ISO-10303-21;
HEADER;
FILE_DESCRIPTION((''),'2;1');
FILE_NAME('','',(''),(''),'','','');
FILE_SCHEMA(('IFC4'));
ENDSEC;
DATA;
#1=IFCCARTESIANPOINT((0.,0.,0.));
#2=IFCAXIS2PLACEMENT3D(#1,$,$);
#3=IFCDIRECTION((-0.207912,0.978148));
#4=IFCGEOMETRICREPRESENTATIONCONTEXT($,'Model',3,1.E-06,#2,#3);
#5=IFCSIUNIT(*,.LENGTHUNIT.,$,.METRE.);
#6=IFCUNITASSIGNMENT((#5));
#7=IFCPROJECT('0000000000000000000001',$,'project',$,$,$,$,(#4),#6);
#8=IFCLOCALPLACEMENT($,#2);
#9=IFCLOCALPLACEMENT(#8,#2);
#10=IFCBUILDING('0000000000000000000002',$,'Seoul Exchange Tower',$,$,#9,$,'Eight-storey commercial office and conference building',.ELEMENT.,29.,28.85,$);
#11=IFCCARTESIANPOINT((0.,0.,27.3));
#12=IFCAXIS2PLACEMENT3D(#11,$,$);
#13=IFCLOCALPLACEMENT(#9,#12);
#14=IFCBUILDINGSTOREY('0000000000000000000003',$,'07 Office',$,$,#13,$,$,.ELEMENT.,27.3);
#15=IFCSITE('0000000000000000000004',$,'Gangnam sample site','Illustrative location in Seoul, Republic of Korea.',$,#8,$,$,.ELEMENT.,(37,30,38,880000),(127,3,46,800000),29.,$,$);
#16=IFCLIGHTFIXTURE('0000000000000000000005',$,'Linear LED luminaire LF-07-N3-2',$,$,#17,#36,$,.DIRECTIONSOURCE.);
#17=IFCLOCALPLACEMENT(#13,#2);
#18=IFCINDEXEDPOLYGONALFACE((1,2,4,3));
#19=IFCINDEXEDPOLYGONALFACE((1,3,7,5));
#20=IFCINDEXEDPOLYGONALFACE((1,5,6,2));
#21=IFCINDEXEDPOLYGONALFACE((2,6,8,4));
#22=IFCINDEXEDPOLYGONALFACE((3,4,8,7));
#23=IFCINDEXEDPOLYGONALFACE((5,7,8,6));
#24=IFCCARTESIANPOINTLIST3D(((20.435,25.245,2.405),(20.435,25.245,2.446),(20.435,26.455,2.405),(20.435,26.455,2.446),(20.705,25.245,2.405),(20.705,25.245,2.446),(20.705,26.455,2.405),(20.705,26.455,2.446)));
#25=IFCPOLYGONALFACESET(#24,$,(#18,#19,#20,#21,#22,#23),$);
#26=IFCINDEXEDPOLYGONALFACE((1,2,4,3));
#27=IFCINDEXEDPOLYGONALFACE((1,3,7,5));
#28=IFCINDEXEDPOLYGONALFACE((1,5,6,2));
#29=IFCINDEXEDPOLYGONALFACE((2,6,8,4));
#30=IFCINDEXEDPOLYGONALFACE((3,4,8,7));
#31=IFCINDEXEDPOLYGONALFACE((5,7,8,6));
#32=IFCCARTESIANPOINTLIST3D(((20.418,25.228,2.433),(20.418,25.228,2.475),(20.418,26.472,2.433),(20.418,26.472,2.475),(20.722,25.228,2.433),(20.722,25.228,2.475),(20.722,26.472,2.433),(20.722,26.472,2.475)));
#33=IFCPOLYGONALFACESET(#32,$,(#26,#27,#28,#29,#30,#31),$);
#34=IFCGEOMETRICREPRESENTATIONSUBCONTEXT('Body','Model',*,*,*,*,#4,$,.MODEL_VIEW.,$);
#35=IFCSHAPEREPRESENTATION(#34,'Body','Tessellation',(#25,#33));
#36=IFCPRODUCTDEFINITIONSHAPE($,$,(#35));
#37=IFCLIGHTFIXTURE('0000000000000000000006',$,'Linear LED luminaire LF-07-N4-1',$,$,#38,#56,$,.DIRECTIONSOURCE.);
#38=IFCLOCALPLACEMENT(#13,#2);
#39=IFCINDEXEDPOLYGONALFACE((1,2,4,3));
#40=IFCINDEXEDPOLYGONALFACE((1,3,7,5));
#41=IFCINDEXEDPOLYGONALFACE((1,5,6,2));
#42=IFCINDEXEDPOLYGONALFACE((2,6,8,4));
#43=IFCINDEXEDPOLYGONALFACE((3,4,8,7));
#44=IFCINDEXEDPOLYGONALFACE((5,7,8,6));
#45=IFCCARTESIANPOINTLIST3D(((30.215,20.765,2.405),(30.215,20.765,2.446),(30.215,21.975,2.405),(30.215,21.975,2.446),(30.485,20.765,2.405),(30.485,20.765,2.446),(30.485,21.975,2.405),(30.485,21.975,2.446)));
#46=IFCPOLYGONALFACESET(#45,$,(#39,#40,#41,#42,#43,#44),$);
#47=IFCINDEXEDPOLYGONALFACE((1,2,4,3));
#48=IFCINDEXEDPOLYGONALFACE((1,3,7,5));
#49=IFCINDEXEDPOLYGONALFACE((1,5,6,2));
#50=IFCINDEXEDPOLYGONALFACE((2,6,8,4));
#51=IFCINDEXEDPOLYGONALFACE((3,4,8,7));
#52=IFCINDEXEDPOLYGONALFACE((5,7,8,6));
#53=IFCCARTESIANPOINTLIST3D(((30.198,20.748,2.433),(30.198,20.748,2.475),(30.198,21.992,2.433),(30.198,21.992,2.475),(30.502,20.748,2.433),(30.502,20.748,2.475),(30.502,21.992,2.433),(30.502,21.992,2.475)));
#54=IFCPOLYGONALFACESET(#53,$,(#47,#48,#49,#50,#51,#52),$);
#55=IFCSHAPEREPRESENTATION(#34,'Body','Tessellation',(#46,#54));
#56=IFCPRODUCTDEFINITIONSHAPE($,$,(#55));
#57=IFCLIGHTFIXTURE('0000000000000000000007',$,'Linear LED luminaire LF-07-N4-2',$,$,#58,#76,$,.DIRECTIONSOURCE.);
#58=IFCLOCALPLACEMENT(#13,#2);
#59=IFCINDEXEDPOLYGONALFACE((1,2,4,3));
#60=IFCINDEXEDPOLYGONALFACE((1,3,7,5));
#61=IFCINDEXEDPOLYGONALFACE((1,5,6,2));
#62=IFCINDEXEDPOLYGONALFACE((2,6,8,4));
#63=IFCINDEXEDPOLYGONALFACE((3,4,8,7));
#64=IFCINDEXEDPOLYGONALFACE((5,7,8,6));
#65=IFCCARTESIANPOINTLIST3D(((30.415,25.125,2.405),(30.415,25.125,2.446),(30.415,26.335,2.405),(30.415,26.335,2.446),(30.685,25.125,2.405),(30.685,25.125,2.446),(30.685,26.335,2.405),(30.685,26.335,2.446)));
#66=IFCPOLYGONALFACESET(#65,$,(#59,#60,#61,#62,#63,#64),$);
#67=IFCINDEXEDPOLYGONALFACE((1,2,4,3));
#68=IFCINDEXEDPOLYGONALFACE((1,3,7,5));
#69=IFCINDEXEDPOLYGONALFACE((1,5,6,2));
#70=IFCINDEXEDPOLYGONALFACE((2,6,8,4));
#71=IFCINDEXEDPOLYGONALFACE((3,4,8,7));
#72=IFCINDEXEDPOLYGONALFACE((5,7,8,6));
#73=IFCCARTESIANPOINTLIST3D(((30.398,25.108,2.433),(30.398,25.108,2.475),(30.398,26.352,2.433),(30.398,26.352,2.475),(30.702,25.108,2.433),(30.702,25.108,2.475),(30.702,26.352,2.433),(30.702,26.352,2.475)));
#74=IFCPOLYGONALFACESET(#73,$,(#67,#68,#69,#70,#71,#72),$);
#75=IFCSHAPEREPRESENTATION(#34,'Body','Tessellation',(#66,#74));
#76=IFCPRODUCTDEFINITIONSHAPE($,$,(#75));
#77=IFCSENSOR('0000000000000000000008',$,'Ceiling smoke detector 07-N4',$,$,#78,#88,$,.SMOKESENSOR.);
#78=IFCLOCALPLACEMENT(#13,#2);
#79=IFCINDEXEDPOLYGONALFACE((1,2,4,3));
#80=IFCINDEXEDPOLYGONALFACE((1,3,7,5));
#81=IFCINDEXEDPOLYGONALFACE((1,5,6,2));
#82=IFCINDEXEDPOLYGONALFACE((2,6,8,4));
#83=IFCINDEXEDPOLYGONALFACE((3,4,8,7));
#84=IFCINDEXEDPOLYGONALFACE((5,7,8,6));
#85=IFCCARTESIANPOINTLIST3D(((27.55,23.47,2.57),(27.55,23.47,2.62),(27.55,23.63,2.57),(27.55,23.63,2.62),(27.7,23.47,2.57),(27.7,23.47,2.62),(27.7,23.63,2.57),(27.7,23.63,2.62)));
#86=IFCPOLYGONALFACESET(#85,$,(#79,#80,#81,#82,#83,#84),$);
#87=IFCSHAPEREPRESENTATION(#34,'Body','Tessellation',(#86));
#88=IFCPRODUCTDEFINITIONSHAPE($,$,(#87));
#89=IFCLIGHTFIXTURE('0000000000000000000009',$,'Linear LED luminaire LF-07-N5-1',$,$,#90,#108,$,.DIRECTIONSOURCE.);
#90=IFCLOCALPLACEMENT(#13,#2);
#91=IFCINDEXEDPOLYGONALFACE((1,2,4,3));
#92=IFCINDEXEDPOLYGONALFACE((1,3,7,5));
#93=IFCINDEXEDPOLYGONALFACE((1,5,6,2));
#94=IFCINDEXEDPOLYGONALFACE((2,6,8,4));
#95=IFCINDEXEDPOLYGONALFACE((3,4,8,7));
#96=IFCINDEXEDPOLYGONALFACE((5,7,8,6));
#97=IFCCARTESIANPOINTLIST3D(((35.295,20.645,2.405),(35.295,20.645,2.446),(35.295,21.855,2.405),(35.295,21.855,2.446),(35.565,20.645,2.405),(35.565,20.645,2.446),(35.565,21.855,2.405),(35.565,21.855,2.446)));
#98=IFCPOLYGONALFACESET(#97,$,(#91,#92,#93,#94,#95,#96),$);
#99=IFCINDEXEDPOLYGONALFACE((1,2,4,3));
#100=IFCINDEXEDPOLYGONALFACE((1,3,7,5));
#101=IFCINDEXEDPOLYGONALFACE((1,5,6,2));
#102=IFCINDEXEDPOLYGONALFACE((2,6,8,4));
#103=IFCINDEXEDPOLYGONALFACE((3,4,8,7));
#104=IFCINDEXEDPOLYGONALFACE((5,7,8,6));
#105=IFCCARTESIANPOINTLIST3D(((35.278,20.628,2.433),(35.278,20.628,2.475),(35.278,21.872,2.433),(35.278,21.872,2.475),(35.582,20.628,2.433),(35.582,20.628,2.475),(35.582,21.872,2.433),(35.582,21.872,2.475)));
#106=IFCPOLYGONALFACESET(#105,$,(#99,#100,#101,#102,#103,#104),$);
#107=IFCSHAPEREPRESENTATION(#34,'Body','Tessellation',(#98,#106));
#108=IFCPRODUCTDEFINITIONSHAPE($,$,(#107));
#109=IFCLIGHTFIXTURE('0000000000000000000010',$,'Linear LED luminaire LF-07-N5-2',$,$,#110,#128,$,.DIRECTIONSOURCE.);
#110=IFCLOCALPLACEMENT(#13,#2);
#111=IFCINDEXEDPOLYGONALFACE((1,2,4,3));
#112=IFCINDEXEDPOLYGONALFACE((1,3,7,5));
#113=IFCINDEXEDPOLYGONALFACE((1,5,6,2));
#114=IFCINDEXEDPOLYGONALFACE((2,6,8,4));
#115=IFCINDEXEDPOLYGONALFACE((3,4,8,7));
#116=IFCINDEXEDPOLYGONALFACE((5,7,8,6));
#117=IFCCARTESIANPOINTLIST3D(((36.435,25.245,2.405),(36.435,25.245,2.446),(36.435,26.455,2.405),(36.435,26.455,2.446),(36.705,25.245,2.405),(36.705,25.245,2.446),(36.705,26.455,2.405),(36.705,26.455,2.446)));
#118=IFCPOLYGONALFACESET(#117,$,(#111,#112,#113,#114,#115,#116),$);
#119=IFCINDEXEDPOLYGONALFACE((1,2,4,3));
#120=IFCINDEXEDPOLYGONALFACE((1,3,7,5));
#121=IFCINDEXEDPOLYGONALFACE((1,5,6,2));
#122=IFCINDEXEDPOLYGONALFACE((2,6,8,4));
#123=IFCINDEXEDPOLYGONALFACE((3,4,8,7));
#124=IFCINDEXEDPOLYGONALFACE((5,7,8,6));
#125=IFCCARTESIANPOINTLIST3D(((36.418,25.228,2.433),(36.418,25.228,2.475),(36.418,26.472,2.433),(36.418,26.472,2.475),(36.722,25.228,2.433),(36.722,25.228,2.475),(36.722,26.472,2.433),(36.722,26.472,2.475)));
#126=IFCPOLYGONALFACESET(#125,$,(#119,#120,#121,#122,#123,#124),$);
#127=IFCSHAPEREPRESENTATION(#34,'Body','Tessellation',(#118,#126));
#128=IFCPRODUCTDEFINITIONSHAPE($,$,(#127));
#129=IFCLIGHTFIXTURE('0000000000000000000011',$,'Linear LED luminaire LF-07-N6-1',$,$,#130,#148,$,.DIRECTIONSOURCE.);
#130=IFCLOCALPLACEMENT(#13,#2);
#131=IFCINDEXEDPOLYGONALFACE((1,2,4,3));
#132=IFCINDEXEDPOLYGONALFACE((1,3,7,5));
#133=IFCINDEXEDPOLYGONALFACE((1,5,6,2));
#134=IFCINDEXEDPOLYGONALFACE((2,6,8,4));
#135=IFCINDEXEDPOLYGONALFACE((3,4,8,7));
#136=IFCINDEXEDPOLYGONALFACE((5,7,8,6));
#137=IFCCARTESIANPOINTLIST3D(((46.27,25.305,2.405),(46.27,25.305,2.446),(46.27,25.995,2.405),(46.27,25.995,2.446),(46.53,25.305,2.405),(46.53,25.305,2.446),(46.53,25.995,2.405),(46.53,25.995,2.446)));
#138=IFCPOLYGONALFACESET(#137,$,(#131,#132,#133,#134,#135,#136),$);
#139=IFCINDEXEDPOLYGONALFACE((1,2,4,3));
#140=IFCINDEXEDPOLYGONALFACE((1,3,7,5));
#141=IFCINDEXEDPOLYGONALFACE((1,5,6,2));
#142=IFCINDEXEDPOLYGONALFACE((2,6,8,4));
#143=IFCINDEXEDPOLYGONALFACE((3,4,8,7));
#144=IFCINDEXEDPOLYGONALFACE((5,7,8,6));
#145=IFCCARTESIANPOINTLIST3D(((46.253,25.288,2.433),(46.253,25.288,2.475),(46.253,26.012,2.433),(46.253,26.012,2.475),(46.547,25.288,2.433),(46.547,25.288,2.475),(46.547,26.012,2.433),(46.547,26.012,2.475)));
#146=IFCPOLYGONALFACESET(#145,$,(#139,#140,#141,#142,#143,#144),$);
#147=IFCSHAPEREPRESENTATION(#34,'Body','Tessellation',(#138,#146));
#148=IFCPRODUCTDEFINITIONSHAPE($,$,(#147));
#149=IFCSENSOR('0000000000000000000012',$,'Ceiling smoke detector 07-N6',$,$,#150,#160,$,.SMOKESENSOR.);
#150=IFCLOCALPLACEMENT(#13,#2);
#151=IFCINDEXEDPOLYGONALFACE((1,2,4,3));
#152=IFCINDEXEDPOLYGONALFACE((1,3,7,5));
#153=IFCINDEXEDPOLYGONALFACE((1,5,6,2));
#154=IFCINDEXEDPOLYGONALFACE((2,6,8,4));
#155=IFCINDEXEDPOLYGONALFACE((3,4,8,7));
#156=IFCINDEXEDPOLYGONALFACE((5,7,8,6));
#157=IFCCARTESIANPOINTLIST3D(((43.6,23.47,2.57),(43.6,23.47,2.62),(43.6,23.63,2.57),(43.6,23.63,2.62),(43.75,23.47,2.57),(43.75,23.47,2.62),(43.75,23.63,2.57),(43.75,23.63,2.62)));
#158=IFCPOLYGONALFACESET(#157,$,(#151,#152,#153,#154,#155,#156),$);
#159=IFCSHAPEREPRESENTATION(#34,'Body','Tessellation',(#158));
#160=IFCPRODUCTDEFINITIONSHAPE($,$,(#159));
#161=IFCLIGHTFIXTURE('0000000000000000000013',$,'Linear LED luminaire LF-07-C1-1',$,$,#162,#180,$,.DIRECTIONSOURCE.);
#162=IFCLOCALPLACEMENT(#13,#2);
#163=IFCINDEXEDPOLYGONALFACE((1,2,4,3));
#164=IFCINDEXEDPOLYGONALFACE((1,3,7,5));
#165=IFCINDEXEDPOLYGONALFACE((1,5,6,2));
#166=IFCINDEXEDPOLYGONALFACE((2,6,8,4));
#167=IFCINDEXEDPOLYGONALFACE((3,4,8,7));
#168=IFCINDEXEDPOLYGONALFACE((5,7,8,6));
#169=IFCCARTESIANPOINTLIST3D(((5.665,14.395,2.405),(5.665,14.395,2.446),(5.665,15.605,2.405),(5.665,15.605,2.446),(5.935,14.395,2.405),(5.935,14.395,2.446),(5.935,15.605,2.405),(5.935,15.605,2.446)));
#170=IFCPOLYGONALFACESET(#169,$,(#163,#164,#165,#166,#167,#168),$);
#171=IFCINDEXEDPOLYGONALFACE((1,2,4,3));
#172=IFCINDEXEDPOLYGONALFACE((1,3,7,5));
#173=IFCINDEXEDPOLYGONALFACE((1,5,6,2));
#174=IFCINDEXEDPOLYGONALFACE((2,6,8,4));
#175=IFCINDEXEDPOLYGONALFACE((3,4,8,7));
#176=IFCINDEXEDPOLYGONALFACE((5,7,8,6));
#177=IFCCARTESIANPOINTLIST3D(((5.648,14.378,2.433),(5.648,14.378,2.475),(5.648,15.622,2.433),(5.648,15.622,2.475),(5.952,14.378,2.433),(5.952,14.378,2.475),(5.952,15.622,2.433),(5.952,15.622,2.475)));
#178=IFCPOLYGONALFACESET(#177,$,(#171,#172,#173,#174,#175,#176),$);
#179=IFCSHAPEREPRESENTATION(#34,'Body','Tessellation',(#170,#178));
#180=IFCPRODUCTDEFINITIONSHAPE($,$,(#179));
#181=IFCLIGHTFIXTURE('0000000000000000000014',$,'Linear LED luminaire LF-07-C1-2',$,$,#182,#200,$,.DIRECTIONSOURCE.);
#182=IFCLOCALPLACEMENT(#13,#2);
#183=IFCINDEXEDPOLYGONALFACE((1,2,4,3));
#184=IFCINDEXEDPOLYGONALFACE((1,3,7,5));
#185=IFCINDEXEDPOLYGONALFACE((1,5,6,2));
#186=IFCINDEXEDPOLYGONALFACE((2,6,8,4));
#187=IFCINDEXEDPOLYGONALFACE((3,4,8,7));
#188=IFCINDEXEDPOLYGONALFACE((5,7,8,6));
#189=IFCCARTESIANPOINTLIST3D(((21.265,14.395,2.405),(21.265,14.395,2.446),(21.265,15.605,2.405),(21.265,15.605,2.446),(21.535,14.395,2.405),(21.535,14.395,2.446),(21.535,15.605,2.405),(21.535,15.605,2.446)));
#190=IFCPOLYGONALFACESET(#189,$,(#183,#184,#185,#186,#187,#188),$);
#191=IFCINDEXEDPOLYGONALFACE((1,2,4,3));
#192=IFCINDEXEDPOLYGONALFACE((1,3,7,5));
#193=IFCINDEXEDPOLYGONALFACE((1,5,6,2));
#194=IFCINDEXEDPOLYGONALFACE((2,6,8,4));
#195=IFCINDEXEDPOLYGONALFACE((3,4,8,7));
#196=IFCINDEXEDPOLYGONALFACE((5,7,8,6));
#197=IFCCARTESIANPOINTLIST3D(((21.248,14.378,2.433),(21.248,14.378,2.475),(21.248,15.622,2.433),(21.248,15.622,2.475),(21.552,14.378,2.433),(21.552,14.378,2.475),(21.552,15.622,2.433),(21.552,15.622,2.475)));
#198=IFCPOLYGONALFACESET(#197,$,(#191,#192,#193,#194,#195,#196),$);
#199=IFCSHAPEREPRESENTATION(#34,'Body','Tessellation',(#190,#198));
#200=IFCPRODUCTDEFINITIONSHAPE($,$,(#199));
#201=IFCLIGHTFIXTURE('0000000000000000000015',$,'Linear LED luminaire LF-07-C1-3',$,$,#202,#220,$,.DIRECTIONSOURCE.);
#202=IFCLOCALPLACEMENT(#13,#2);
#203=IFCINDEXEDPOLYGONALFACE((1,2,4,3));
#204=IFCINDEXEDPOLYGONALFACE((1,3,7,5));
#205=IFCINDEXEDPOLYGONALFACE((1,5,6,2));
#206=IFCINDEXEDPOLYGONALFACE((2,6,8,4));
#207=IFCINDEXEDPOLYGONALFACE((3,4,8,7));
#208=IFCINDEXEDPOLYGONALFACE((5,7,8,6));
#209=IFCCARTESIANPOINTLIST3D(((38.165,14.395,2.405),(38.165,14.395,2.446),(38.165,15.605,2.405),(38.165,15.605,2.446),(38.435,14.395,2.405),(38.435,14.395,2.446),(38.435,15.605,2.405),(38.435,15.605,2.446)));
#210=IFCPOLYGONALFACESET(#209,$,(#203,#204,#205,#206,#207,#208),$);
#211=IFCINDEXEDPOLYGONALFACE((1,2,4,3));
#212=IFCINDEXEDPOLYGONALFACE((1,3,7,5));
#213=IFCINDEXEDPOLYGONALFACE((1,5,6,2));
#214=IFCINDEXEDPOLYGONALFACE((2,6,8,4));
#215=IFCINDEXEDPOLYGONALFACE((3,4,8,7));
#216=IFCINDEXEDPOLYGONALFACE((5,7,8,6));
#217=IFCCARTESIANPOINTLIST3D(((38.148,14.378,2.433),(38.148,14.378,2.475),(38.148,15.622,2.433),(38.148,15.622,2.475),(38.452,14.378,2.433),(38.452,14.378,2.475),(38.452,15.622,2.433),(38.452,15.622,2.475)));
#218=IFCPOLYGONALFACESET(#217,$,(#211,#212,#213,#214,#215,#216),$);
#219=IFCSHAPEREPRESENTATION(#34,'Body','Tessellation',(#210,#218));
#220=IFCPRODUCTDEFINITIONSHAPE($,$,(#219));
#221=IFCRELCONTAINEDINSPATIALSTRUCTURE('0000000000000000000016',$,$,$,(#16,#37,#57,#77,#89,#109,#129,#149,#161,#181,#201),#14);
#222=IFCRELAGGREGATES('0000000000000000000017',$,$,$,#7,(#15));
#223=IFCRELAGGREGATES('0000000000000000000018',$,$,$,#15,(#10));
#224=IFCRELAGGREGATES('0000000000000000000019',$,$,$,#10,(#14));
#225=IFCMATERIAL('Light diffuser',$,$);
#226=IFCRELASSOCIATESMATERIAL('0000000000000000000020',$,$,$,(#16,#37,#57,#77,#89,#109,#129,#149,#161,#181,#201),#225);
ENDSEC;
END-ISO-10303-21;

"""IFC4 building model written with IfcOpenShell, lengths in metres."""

from ifc_helpers import new_model, si_unit, direction, frame, frame_2d, origin, place, context, subcontext, project, spatial, rectangle, extrude, material, element, save


model = new_model("IFC4")

# Units and contexts
model_context = context("Model", 3, precision=1e-06, world=origin(), true_north=direction((-0.207912, 0.978148)))
body_context = subcontext(model_context, "Body", "Model", "MODEL_VIEW")
ifc_project = project(units=[si_unit("LENGTHUNIT", "METRE")], contexts=[model_context])

# Site, building, storey
site_placement = place(None, origin())
site = spatial("IfcSite", under=ifc_project, at=site_placement, Name="Gangnam sample site", Description="Illustrative location in Seoul, Republic of Korea.", CompositionType="ELEMENT", RefLatitude=(37, 30, 38, 880000), RefLongitude=(127, 3, 46, 800000), RefElevation=29.0)
building_placement = place(site_placement, origin())
building = spatial("IfcBuilding", under=site, at=building_placement, Name="Seoul Exchange Tower", LongName="Eight-storey commercial office and conference building", CompositionType="ELEMENT", ElevationOfRefHeight=29.0, ElevationOfTerrain=28.85)
storey_placement = place(building_placement, frame((0.0, 0.0, 27.3)))
storey = spatial("IfcBuildingStorey", under=building, at=storey_placement, Name="07 Office", CompositionType="ELEMENT", Elevation=27.3)

# Shared definitions
placement = place(storey_placement, origin())

# Shared definitions
ifc_material_1 = material(Name="Light diffuser")

# Light fixtures
element("IfcLightFixture", 1, at=placement, inside=storey, material=ifc_material_1, Name="Linear LED luminaire LF-07-N3-2", PredefinedType="DIRECTIONSOURCE", context=body_context, shape_type="SweptSolid", body=[
    extrude(rectangle(XDim=0.27, YDim=1.21, at=frame_2d((0.135, 0.605))), frame((20.435, 25.245, 2.405)), (0.0, 0.0, 1.0), 0.041),
    extrude(rectangle(XDim=0.304, YDim=1.244, at=frame_2d((0.152, 0.622))), frame((20.418, 25.228, 2.433)), (0.0, 0.0, 1.0), 0.042),
])
element("IfcLightFixture", 2, at=placement, inside=storey, material=ifc_material_1, Name="Linear LED luminaire LF-07-N4-1", PredefinedType="DIRECTIONSOURCE", context=body_context, shape_type="SweptSolid", body=[
    extrude(rectangle(XDim=0.27, YDim=1.21, at=frame_2d((0.135, 0.605))), frame((30.215, 20.765, 2.405)), (0.0, 0.0, 1.0), 0.041),
    extrude(rectangle(XDim=0.304, YDim=1.244, at=frame_2d((0.152, 0.622))), frame((30.198, 20.748, 2.433)), (0.0, 0.0, 1.0), 0.042),
])
element("IfcLightFixture", 3, at=placement, inside=storey, material=ifc_material_1, Name="Linear LED luminaire LF-07-N4-2", PredefinedType="DIRECTIONSOURCE", context=body_context, shape_type="SweptSolid", body=[
    extrude(rectangle(XDim=0.27, YDim=1.21, at=frame_2d((0.135, 0.605))), frame((30.415, 25.125, 2.405)), (0.0, 0.0, 1.0), 0.041),
    extrude(rectangle(XDim=0.304, YDim=1.244, at=frame_2d((0.152, 0.622))), frame((30.398, 25.108, 2.433)), (0.0, 0.0, 1.0), 0.042),
])

# Sensor
element("IfcSensor", 4, at=placement, inside=storey, material=ifc_material_1, Name="Ceiling smoke detector 07-N4", PredefinedType="SMOKESENSOR", context=body_context, shape_type="SweptSolid", body=[
    extrude(rectangle(XDim=0.15, YDim=0.16, at=frame_2d((0.075, 0.08))), frame((27.55, 23.47, 2.57)), (0.0, 0.0, 1.0), 0.05),
])

# Light fixtures
element("IfcLightFixture", 5, at=placement, inside=storey, material=ifc_material_1, Name="Linear LED luminaire LF-07-N5-1", PredefinedType="DIRECTIONSOURCE", context=body_context, shape_type="SweptSolid", body=[
    extrude(rectangle(XDim=0.27, YDim=1.21, at=frame_2d((0.135, 0.605))), frame((35.295, 20.645, 2.405)), (0.0, 0.0, 1.0), 0.041),
    extrude(rectangle(XDim=0.304, YDim=1.244, at=frame_2d((0.152, 0.622))), frame((35.278, 20.628, 2.433)), (0.0, 0.0, 1.0), 0.042),
])
element("IfcLightFixture", 6, at=placement, inside=storey, material=ifc_material_1, Name="Linear LED luminaire LF-07-N5-2", PredefinedType="DIRECTIONSOURCE", context=body_context, shape_type="SweptSolid", body=[
    extrude(rectangle(XDim=0.27, YDim=1.21, at=frame_2d((0.135, 0.605))), frame((36.435, 25.245, 2.405)), (0.0, 0.0, 1.0), 0.041),
    extrude(rectangle(XDim=0.304, YDim=1.244, at=frame_2d((0.152, 0.622))), frame((36.418, 25.228, 2.433)), (0.0, 0.0, 1.0), 0.042),
])
element("IfcLightFixture", 7, at=placement, inside=storey, material=ifc_material_1, Name="Linear LED luminaire LF-07-N6-1", PredefinedType="DIRECTIONSOURCE", context=body_context, shape_type="SweptSolid", body=[
    extrude(rectangle(XDim=0.26, YDim=0.69, at=frame_2d((0.13, 0.345))), frame((46.27, 25.305, 2.405)), (0.0, 0.0, 1.0), 0.041),
    extrude(rectangle(XDim=0.294, YDim=0.724, at=frame_2d((0.147, 0.362))), frame((46.253, 25.288, 2.433)), (0.0, 0.0, 1.0), 0.042),
])

# Sensor
element("IfcSensor", 8, at=placement, inside=storey, material=ifc_material_1, Name="Ceiling smoke detector 07-N6", PredefinedType="SMOKESENSOR", context=body_context, shape_type="SweptSolid", body=[
    extrude(rectangle(XDim=0.15, YDim=0.16, at=frame_2d((0.075, 0.08))), frame((43.6, 23.47, 2.57)), (0.0, 0.0, 1.0), 0.05),
])

# Light fixtures
element("IfcLightFixture", 9, at=placement, inside=storey, material=ifc_material_1, Name="Linear LED luminaire LF-07-C1-1", PredefinedType="DIRECTIONSOURCE", context=body_context, shape_type="SweptSolid", body=[
    extrude(rectangle(XDim=0.27, YDim=1.21, at=frame_2d((0.135, 0.605))), frame((5.665, 14.395, 2.405)), (0.0, 0.0, 1.0), 0.041),
    extrude(rectangle(XDim=0.304, YDim=1.244, at=frame_2d((0.152, 0.622))), frame((5.648, 14.378, 2.433)), (0.0, 0.0, 1.0), 0.042),
])
element("IfcLightFixture", 10, at=placement, inside=storey, material=ifc_material_1, Name="Linear LED luminaire LF-07-C1-2", PredefinedType="DIRECTIONSOURCE", context=body_context, shape_type="SweptSolid", body=[
    extrude(rectangle(XDim=0.27, YDim=1.21, at=frame_2d((0.135, 0.605))), frame((21.265, 14.395, 2.405)), (0.0, 0.0, 1.0), 0.041),
    extrude(rectangle(XDim=0.304, YDim=1.244, at=frame_2d((0.152, 0.622))), frame((21.248, 14.378, 2.433)), (0.0, 0.0, 1.0), 0.042),
])
element("IfcLightFixture", 11, at=placement, inside=storey, material=ifc_material_1, Name="Linear LED luminaire LF-07-C1-3", PredefinedType="DIRECTIONSOURCE", context=body_context, shape_type="SweptSolid", body=[
    extrude(rectangle(XDim=0.27, YDim=1.21, at=frame_2d((0.135, 0.605))), frame((38.165, 14.395, 2.405)), (0.0, 0.0, 1.0), 0.041),
    extrude(rectangle(XDim=0.304, YDim=1.244, at=frame_2d((0.152, 0.622))), frame((38.148, 14.378, 2.433)), (0.0, 0.0, 1.0), 0.042),
])

save(model, "model.ifc")
